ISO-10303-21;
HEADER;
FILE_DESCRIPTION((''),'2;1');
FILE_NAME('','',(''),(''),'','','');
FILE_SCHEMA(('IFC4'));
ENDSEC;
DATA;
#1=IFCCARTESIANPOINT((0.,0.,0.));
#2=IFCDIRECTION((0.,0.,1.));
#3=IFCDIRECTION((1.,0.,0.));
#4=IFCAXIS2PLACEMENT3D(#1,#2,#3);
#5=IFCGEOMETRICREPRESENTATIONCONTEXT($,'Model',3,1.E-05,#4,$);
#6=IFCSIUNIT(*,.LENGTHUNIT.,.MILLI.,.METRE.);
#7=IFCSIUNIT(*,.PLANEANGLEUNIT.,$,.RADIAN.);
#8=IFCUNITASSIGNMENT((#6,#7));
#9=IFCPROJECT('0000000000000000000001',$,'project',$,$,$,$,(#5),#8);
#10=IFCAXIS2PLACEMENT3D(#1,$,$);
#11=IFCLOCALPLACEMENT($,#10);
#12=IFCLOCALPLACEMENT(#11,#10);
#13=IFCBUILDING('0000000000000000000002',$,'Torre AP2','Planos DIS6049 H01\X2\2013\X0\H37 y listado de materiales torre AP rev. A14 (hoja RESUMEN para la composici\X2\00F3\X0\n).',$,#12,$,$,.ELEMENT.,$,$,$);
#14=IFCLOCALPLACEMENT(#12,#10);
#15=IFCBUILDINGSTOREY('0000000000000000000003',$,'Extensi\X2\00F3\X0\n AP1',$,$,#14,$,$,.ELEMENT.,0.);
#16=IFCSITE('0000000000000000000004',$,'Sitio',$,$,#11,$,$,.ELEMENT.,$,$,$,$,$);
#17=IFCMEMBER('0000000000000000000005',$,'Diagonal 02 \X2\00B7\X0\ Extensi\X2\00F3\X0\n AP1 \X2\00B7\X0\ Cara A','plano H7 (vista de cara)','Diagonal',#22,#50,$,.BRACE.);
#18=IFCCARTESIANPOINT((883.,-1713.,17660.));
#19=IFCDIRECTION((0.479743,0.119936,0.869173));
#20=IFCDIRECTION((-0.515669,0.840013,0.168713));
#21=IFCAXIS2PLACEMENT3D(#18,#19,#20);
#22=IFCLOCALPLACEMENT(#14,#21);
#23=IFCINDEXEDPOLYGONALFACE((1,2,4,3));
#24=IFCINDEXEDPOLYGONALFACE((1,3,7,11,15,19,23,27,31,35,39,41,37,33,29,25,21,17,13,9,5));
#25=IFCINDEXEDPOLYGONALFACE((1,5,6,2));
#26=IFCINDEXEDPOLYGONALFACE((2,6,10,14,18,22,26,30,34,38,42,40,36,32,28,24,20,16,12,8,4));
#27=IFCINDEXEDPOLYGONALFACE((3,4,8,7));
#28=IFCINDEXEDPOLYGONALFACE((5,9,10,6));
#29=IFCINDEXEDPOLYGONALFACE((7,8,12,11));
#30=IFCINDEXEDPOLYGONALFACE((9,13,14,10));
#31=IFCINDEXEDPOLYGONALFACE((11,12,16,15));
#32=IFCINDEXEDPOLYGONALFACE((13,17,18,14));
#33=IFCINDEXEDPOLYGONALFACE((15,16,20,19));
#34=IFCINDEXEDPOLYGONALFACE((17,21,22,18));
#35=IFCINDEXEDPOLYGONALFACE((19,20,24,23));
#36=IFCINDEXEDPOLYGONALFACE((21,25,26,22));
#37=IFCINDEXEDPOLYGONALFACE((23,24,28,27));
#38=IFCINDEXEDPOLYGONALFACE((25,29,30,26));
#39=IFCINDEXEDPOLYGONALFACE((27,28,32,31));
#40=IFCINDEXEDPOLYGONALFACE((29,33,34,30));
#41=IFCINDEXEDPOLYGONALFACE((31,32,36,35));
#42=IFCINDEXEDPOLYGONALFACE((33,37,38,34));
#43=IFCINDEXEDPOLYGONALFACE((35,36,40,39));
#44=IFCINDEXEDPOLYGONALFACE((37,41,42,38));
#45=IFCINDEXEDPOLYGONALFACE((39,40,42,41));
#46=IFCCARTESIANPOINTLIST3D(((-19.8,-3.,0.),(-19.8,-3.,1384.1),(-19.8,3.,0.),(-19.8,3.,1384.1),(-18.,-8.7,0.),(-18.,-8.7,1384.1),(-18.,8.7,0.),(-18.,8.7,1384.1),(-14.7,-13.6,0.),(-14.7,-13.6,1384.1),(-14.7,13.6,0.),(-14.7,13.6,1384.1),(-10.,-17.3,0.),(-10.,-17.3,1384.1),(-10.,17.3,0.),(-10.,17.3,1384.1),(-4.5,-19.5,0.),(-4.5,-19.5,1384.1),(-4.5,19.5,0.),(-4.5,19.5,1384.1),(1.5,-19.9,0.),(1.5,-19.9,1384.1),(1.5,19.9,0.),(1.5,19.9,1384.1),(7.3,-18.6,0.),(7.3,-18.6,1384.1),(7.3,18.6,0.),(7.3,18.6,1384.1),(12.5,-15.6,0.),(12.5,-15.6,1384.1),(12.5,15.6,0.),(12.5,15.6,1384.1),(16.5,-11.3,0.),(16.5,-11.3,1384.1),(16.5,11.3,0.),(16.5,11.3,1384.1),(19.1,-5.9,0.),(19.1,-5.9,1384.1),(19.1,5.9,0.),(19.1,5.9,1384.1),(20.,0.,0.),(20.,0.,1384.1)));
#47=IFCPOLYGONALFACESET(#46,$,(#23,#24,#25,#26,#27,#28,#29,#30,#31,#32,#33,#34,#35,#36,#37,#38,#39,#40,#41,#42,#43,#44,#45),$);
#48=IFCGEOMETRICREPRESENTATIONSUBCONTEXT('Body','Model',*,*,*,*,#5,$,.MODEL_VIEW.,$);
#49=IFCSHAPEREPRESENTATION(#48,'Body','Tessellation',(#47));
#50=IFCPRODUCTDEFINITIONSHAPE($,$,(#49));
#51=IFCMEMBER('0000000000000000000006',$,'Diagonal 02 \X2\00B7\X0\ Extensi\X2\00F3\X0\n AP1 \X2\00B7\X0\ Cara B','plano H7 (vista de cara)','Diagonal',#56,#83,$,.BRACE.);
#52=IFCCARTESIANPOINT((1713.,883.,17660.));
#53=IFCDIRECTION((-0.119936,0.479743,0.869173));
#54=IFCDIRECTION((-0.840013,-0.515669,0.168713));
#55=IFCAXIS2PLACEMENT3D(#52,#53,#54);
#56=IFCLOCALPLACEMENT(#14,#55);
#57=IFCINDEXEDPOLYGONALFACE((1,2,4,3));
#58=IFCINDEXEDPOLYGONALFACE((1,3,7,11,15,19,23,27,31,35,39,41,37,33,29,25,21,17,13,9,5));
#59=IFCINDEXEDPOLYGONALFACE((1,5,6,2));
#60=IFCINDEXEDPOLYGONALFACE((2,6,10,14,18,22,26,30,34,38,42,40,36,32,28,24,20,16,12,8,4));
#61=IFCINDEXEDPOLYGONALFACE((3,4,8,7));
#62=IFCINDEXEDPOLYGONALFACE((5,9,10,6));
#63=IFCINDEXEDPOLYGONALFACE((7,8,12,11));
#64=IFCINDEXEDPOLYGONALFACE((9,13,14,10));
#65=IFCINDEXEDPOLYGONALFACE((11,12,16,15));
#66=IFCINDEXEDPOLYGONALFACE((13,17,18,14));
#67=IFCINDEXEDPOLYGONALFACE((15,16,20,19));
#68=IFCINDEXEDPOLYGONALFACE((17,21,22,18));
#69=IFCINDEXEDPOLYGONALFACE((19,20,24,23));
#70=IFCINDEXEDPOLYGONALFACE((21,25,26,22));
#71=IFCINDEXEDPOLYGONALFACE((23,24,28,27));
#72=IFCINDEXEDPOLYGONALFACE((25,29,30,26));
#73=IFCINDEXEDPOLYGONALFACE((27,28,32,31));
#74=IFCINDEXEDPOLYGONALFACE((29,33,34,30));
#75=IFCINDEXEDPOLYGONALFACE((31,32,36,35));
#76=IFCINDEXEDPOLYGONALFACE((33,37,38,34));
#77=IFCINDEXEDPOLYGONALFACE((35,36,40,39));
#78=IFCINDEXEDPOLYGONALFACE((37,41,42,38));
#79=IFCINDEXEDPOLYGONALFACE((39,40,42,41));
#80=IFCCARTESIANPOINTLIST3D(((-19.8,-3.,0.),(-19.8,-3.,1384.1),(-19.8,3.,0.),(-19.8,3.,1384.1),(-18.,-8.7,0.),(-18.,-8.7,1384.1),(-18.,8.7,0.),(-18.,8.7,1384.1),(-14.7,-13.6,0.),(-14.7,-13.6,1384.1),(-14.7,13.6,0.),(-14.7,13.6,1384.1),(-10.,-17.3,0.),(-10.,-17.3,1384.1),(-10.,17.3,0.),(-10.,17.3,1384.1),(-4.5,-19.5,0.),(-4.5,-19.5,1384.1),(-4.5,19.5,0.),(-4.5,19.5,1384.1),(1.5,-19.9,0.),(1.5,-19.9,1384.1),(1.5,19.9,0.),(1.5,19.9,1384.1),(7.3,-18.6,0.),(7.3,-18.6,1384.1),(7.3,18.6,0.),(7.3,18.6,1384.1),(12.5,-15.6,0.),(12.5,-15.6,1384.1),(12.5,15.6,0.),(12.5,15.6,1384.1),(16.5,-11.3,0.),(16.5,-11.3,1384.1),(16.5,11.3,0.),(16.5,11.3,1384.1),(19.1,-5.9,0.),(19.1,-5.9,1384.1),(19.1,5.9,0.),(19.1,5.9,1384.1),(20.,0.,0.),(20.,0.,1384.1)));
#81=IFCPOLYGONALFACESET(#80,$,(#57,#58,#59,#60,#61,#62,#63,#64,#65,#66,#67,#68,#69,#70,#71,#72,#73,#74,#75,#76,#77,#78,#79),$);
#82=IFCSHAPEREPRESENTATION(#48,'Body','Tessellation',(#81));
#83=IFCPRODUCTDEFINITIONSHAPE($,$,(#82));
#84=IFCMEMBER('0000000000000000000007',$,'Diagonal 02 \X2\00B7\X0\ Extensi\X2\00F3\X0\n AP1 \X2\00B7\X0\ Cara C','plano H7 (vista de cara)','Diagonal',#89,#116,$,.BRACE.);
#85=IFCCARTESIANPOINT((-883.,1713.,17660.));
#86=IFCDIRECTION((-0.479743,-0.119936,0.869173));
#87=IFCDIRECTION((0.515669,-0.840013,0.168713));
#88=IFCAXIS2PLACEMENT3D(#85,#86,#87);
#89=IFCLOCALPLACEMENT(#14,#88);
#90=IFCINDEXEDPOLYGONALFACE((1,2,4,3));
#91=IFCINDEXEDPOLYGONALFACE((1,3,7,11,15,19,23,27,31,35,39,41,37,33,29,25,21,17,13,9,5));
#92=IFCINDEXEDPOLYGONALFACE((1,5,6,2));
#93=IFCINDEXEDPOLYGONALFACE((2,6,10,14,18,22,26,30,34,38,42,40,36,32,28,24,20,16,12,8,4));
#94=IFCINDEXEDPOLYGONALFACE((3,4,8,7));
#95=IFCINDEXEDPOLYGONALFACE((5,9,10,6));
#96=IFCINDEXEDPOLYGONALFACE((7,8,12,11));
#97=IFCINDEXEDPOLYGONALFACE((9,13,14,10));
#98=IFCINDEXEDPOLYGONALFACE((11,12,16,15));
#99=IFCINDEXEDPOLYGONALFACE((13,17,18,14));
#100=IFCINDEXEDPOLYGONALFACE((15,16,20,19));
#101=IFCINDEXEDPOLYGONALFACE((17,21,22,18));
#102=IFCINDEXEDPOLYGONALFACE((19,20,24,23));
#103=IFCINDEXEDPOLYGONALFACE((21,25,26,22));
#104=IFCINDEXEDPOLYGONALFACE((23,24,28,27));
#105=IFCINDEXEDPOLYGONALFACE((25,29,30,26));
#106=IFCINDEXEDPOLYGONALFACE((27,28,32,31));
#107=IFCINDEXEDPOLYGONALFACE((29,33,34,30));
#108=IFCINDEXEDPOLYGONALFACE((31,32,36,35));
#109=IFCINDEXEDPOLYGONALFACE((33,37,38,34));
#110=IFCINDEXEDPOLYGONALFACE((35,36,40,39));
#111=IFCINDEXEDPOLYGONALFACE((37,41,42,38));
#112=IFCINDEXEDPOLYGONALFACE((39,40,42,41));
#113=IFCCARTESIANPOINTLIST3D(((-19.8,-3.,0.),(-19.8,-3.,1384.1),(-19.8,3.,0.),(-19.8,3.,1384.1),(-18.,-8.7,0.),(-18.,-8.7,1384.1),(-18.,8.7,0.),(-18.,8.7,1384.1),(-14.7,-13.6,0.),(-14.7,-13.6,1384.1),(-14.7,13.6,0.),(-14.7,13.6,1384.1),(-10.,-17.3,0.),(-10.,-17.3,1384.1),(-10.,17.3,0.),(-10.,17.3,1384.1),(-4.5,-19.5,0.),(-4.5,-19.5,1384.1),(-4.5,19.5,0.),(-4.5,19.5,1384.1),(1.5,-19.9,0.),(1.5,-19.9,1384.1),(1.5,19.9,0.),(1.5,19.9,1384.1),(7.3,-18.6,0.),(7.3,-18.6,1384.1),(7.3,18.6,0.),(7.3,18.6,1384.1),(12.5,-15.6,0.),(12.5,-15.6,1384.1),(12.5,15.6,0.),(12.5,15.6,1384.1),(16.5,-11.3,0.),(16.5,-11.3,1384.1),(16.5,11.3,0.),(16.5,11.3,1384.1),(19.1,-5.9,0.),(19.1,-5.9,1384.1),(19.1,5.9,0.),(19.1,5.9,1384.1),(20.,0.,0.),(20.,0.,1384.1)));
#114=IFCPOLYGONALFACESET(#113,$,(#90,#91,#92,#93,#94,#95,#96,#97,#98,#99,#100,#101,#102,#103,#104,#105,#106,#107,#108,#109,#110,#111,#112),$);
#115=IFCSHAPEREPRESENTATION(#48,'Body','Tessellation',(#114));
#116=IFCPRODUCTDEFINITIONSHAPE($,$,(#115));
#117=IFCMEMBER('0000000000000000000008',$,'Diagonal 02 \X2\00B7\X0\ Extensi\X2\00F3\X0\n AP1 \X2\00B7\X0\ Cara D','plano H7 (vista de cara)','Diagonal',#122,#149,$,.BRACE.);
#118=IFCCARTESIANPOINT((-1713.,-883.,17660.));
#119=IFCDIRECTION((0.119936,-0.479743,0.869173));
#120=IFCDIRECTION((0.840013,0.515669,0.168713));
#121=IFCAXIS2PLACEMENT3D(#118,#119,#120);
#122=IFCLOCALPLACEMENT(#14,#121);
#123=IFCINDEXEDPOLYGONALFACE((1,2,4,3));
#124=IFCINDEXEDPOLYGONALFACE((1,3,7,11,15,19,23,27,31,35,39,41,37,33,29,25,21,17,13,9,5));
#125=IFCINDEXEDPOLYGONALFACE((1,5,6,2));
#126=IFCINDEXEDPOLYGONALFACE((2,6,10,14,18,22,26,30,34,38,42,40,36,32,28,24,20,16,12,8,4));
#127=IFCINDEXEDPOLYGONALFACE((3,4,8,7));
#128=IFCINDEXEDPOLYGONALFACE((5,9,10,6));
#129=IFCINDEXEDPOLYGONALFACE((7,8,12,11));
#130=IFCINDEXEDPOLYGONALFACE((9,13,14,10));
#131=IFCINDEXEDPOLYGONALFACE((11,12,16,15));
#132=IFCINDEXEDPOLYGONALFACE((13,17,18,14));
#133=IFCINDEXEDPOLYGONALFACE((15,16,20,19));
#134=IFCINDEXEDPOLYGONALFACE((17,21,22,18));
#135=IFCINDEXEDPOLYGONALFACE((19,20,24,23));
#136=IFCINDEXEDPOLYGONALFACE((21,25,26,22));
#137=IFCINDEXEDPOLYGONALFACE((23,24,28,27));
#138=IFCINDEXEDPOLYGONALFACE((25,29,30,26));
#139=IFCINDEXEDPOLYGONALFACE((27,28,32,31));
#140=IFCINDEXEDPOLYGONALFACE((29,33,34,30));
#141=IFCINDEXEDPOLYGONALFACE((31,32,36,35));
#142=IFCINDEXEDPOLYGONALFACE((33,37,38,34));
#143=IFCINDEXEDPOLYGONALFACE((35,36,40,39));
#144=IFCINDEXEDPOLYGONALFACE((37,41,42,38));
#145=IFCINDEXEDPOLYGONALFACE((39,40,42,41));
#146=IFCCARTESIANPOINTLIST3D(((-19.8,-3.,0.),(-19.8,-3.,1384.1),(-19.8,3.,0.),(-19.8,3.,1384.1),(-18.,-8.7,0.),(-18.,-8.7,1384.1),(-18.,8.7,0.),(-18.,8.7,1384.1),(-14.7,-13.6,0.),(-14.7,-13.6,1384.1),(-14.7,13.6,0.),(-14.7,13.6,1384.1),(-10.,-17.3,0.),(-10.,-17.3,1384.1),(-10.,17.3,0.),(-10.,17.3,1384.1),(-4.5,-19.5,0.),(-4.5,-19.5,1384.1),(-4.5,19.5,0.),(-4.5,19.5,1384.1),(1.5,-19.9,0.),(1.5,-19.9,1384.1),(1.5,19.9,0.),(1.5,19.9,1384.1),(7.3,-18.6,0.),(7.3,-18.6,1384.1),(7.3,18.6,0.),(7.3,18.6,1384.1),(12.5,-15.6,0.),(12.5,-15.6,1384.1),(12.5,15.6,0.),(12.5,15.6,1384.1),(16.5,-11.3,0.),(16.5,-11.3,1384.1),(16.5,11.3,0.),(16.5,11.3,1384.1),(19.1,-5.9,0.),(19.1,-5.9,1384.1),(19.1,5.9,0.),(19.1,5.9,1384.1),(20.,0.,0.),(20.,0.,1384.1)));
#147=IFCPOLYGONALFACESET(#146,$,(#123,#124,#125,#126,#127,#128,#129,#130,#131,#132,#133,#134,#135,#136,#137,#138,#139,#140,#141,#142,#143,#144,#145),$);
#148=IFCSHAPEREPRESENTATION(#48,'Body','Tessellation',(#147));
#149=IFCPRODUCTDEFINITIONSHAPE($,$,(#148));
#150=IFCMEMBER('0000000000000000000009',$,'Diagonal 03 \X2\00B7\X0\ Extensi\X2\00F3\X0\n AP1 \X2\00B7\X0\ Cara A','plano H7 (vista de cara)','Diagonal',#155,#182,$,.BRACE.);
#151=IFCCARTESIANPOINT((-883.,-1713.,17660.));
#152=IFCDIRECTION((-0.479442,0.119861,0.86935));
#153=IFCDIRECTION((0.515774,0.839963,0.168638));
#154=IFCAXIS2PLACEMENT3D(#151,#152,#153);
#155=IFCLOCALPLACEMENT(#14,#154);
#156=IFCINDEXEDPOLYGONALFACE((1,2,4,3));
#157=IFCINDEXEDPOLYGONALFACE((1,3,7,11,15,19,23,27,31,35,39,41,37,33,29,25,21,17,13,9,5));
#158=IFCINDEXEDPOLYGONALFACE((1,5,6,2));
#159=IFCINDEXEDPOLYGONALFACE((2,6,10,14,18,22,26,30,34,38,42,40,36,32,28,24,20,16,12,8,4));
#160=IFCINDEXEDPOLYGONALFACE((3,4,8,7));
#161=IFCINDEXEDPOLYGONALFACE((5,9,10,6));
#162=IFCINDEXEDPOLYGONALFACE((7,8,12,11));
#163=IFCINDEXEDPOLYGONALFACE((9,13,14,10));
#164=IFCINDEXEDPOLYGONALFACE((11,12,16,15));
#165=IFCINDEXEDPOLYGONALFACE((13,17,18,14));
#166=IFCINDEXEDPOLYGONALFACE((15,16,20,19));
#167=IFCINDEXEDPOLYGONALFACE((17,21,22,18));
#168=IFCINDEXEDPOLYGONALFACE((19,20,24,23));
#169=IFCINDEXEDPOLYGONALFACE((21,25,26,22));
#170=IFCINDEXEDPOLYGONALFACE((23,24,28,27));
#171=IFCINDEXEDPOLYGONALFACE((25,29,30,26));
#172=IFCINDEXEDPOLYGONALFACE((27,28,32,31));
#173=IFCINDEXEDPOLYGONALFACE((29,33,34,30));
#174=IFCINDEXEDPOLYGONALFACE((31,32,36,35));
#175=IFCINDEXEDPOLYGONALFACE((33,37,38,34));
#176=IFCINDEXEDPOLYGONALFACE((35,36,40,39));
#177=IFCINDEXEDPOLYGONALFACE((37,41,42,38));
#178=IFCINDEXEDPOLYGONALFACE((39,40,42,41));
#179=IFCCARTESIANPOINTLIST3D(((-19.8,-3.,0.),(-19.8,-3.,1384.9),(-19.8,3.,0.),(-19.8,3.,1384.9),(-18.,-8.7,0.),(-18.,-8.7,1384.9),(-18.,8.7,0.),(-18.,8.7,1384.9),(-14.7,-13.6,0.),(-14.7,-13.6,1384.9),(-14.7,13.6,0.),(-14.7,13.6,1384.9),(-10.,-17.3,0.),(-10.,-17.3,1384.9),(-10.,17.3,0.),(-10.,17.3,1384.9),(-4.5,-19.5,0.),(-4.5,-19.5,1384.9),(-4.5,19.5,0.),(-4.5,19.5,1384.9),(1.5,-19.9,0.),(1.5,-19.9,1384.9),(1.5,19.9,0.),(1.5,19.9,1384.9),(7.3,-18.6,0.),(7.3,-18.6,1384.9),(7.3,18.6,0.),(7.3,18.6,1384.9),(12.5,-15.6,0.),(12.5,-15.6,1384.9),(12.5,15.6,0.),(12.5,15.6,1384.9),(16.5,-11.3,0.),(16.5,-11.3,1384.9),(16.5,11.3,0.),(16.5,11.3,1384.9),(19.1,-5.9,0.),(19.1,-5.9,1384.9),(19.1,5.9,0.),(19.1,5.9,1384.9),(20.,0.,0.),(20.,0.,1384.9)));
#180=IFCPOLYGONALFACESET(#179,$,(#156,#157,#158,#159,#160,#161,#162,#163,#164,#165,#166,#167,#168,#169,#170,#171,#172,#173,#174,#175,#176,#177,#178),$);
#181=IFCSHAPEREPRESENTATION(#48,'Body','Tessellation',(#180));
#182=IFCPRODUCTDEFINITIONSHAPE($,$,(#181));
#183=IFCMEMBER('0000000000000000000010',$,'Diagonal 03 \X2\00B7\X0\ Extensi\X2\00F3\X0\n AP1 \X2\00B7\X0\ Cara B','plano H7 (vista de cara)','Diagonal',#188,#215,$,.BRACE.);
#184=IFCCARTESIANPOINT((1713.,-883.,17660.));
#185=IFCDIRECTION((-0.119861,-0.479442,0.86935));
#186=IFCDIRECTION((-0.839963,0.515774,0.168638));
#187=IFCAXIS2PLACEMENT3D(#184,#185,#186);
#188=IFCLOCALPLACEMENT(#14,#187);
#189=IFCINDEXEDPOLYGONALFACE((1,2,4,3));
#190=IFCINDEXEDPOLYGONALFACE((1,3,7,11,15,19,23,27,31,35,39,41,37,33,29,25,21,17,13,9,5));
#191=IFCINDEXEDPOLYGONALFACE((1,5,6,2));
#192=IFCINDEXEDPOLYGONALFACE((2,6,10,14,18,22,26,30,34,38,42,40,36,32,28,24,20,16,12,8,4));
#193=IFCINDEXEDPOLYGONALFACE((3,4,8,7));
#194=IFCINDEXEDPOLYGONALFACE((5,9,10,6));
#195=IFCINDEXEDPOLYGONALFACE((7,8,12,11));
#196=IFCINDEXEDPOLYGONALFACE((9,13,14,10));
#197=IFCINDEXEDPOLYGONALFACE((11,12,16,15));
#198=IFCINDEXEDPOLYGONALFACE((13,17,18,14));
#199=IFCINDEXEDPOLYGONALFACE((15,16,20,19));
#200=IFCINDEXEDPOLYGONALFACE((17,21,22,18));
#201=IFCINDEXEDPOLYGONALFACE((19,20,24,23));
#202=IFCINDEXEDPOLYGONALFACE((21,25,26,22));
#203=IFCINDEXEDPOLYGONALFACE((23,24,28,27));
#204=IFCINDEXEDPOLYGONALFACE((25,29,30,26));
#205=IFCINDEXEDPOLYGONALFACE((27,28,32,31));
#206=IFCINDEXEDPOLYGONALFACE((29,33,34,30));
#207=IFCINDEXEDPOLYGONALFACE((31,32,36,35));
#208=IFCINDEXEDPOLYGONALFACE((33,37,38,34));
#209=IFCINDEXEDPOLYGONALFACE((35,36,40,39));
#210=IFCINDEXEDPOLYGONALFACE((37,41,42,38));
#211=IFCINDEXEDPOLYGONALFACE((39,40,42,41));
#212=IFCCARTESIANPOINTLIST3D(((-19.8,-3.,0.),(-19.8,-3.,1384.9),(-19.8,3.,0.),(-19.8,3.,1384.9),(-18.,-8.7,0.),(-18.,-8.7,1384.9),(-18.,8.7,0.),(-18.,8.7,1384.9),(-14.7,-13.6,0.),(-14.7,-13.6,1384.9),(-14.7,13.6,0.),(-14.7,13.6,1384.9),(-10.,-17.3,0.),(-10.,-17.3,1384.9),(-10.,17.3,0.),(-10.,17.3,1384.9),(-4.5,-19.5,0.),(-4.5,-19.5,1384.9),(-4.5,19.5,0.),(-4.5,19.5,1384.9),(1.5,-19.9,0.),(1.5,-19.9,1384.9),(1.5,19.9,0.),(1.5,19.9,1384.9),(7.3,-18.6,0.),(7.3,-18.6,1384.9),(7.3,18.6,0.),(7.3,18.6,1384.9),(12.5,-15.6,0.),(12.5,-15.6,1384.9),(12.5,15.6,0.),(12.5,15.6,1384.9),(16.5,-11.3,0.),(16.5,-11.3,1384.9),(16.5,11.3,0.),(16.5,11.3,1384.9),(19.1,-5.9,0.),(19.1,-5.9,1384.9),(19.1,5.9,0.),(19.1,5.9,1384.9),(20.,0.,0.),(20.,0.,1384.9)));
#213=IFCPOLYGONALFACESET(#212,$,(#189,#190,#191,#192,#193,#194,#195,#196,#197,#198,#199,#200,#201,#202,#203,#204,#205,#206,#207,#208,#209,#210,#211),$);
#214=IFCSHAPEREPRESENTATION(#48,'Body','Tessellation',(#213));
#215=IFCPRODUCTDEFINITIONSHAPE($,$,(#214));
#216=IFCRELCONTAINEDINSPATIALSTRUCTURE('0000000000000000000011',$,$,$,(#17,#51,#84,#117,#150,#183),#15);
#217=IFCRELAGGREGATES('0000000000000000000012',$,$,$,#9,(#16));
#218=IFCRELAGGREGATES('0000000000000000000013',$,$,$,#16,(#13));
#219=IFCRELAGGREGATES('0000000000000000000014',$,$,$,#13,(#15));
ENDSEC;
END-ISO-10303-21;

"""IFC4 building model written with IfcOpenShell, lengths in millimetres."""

from ifc_helpers import new_model, si_unit, frame, origin, origin_with_axes, place, context, subcontext, project, spatial, circle, extrude, element, save


model = new_model("IFC4")

# Units and contexts
model_context = context("Model", 3, precision=1e-05, world=origin_with_axes())
body_context = subcontext(model_context, "Body", "Model", "MODEL_VIEW")
ifc_project = project(units=[si_unit("LENGTHUNIT", "METRE", prefix="MILLI"), si_unit("PLANEANGLEUNIT", "RADIAN")], contexts=[model_context])

# Site, building, storey
site_placement = place(None, origin())
site = spatial("IfcSite", under=ifc_project, at=site_placement, Name="Sitio", CompositionType="ELEMENT")
building_placement = place(site_placement, origin())
building = spatial("IfcBuilding", under=site, at=building_placement, Name="Torre AP2", Description="Planos DIS6049 H01–H37 y listado de materiales torre AP rev. A14 (hoja RESUMEN para la composición).", CompositionType="ELEMENT")
storey_placement = place(building_placement, origin())
storey = spatial("IfcBuildingStorey", under=building, at=storey_placement, Name="Extensión AP1", CompositionType="ELEMENT", Elevation=0.0)

# Members
for number, where, z_axis, x_axis, name in (
    (1, (883.0, -1713.0, 17660.0), (0.479743, 0.119936, 0.869173), (-0.515669, 0.840013, 0.168713), "Diagonal 02 · Extensión AP1 · Cara A"),
    (2, (1713.0, 883.0, 17660.0), (-0.119936, 0.479743, 0.869173), (-0.840013, -0.515669, 0.168713), "Diagonal 02 · Extensión AP1 · Cara B"),
    (3, (-883.0, 1713.0, 17660.0), (-0.479743, -0.119936, 0.869173), (0.515669, -0.840013, 0.168713), "Diagonal 02 · Extensión AP1 · Cara C"),
    (4, (-1713.0, -883.0, 17660.0), (0.119936, -0.479743, 0.869173), (0.840013, 0.515669, 0.168713), "Diagonal 02 · Extensión AP1 · Cara D"),
):
    element("IfcMember", number, at=place(storey_placement, frame(where, z_axis=z_axis, x_axis=x_axis)), inside=storey, Name=name, Description="plano H7 (vista de cara)", ObjectType="Diagonal", PredefinedType="BRACE", context=body_context, shape_type="SweptSolid", body=[
        extrude(circle(Radius=20.0), None, (0.0, 0.0, 1.0), 1384.1),
    ])
for number, where, z_axis, x_axis, name in (
    (5, (-883.0, -1713.0, 17660.0), (-0.479442, 0.119861, 0.86935), (0.515774, 0.839963, 0.168638), "Diagonal 03 · Extensión AP1 · Cara A"),
    (6, (1713.0, -883.0, 17660.0), (-0.119861, -0.479442, 0.86935), (-0.839963, 0.515774, 0.168638), "Diagonal 03 · Extensión AP1 · Cara B"),
):
    element("IfcMember", number, at=place(storey_placement, frame(where, z_axis=z_axis, x_axis=x_axis)), inside=storey, Name=name, Description="plano H7 (vista de cara)", ObjectType="Diagonal", PredefinedType="BRACE", context=body_context, shape_type="SweptSolid", body=[
        extrude(circle(Radius=20.0), None, (0.0, 0.0, 1.0), 1384.9),
    ])

save(model, "model.ifc")
